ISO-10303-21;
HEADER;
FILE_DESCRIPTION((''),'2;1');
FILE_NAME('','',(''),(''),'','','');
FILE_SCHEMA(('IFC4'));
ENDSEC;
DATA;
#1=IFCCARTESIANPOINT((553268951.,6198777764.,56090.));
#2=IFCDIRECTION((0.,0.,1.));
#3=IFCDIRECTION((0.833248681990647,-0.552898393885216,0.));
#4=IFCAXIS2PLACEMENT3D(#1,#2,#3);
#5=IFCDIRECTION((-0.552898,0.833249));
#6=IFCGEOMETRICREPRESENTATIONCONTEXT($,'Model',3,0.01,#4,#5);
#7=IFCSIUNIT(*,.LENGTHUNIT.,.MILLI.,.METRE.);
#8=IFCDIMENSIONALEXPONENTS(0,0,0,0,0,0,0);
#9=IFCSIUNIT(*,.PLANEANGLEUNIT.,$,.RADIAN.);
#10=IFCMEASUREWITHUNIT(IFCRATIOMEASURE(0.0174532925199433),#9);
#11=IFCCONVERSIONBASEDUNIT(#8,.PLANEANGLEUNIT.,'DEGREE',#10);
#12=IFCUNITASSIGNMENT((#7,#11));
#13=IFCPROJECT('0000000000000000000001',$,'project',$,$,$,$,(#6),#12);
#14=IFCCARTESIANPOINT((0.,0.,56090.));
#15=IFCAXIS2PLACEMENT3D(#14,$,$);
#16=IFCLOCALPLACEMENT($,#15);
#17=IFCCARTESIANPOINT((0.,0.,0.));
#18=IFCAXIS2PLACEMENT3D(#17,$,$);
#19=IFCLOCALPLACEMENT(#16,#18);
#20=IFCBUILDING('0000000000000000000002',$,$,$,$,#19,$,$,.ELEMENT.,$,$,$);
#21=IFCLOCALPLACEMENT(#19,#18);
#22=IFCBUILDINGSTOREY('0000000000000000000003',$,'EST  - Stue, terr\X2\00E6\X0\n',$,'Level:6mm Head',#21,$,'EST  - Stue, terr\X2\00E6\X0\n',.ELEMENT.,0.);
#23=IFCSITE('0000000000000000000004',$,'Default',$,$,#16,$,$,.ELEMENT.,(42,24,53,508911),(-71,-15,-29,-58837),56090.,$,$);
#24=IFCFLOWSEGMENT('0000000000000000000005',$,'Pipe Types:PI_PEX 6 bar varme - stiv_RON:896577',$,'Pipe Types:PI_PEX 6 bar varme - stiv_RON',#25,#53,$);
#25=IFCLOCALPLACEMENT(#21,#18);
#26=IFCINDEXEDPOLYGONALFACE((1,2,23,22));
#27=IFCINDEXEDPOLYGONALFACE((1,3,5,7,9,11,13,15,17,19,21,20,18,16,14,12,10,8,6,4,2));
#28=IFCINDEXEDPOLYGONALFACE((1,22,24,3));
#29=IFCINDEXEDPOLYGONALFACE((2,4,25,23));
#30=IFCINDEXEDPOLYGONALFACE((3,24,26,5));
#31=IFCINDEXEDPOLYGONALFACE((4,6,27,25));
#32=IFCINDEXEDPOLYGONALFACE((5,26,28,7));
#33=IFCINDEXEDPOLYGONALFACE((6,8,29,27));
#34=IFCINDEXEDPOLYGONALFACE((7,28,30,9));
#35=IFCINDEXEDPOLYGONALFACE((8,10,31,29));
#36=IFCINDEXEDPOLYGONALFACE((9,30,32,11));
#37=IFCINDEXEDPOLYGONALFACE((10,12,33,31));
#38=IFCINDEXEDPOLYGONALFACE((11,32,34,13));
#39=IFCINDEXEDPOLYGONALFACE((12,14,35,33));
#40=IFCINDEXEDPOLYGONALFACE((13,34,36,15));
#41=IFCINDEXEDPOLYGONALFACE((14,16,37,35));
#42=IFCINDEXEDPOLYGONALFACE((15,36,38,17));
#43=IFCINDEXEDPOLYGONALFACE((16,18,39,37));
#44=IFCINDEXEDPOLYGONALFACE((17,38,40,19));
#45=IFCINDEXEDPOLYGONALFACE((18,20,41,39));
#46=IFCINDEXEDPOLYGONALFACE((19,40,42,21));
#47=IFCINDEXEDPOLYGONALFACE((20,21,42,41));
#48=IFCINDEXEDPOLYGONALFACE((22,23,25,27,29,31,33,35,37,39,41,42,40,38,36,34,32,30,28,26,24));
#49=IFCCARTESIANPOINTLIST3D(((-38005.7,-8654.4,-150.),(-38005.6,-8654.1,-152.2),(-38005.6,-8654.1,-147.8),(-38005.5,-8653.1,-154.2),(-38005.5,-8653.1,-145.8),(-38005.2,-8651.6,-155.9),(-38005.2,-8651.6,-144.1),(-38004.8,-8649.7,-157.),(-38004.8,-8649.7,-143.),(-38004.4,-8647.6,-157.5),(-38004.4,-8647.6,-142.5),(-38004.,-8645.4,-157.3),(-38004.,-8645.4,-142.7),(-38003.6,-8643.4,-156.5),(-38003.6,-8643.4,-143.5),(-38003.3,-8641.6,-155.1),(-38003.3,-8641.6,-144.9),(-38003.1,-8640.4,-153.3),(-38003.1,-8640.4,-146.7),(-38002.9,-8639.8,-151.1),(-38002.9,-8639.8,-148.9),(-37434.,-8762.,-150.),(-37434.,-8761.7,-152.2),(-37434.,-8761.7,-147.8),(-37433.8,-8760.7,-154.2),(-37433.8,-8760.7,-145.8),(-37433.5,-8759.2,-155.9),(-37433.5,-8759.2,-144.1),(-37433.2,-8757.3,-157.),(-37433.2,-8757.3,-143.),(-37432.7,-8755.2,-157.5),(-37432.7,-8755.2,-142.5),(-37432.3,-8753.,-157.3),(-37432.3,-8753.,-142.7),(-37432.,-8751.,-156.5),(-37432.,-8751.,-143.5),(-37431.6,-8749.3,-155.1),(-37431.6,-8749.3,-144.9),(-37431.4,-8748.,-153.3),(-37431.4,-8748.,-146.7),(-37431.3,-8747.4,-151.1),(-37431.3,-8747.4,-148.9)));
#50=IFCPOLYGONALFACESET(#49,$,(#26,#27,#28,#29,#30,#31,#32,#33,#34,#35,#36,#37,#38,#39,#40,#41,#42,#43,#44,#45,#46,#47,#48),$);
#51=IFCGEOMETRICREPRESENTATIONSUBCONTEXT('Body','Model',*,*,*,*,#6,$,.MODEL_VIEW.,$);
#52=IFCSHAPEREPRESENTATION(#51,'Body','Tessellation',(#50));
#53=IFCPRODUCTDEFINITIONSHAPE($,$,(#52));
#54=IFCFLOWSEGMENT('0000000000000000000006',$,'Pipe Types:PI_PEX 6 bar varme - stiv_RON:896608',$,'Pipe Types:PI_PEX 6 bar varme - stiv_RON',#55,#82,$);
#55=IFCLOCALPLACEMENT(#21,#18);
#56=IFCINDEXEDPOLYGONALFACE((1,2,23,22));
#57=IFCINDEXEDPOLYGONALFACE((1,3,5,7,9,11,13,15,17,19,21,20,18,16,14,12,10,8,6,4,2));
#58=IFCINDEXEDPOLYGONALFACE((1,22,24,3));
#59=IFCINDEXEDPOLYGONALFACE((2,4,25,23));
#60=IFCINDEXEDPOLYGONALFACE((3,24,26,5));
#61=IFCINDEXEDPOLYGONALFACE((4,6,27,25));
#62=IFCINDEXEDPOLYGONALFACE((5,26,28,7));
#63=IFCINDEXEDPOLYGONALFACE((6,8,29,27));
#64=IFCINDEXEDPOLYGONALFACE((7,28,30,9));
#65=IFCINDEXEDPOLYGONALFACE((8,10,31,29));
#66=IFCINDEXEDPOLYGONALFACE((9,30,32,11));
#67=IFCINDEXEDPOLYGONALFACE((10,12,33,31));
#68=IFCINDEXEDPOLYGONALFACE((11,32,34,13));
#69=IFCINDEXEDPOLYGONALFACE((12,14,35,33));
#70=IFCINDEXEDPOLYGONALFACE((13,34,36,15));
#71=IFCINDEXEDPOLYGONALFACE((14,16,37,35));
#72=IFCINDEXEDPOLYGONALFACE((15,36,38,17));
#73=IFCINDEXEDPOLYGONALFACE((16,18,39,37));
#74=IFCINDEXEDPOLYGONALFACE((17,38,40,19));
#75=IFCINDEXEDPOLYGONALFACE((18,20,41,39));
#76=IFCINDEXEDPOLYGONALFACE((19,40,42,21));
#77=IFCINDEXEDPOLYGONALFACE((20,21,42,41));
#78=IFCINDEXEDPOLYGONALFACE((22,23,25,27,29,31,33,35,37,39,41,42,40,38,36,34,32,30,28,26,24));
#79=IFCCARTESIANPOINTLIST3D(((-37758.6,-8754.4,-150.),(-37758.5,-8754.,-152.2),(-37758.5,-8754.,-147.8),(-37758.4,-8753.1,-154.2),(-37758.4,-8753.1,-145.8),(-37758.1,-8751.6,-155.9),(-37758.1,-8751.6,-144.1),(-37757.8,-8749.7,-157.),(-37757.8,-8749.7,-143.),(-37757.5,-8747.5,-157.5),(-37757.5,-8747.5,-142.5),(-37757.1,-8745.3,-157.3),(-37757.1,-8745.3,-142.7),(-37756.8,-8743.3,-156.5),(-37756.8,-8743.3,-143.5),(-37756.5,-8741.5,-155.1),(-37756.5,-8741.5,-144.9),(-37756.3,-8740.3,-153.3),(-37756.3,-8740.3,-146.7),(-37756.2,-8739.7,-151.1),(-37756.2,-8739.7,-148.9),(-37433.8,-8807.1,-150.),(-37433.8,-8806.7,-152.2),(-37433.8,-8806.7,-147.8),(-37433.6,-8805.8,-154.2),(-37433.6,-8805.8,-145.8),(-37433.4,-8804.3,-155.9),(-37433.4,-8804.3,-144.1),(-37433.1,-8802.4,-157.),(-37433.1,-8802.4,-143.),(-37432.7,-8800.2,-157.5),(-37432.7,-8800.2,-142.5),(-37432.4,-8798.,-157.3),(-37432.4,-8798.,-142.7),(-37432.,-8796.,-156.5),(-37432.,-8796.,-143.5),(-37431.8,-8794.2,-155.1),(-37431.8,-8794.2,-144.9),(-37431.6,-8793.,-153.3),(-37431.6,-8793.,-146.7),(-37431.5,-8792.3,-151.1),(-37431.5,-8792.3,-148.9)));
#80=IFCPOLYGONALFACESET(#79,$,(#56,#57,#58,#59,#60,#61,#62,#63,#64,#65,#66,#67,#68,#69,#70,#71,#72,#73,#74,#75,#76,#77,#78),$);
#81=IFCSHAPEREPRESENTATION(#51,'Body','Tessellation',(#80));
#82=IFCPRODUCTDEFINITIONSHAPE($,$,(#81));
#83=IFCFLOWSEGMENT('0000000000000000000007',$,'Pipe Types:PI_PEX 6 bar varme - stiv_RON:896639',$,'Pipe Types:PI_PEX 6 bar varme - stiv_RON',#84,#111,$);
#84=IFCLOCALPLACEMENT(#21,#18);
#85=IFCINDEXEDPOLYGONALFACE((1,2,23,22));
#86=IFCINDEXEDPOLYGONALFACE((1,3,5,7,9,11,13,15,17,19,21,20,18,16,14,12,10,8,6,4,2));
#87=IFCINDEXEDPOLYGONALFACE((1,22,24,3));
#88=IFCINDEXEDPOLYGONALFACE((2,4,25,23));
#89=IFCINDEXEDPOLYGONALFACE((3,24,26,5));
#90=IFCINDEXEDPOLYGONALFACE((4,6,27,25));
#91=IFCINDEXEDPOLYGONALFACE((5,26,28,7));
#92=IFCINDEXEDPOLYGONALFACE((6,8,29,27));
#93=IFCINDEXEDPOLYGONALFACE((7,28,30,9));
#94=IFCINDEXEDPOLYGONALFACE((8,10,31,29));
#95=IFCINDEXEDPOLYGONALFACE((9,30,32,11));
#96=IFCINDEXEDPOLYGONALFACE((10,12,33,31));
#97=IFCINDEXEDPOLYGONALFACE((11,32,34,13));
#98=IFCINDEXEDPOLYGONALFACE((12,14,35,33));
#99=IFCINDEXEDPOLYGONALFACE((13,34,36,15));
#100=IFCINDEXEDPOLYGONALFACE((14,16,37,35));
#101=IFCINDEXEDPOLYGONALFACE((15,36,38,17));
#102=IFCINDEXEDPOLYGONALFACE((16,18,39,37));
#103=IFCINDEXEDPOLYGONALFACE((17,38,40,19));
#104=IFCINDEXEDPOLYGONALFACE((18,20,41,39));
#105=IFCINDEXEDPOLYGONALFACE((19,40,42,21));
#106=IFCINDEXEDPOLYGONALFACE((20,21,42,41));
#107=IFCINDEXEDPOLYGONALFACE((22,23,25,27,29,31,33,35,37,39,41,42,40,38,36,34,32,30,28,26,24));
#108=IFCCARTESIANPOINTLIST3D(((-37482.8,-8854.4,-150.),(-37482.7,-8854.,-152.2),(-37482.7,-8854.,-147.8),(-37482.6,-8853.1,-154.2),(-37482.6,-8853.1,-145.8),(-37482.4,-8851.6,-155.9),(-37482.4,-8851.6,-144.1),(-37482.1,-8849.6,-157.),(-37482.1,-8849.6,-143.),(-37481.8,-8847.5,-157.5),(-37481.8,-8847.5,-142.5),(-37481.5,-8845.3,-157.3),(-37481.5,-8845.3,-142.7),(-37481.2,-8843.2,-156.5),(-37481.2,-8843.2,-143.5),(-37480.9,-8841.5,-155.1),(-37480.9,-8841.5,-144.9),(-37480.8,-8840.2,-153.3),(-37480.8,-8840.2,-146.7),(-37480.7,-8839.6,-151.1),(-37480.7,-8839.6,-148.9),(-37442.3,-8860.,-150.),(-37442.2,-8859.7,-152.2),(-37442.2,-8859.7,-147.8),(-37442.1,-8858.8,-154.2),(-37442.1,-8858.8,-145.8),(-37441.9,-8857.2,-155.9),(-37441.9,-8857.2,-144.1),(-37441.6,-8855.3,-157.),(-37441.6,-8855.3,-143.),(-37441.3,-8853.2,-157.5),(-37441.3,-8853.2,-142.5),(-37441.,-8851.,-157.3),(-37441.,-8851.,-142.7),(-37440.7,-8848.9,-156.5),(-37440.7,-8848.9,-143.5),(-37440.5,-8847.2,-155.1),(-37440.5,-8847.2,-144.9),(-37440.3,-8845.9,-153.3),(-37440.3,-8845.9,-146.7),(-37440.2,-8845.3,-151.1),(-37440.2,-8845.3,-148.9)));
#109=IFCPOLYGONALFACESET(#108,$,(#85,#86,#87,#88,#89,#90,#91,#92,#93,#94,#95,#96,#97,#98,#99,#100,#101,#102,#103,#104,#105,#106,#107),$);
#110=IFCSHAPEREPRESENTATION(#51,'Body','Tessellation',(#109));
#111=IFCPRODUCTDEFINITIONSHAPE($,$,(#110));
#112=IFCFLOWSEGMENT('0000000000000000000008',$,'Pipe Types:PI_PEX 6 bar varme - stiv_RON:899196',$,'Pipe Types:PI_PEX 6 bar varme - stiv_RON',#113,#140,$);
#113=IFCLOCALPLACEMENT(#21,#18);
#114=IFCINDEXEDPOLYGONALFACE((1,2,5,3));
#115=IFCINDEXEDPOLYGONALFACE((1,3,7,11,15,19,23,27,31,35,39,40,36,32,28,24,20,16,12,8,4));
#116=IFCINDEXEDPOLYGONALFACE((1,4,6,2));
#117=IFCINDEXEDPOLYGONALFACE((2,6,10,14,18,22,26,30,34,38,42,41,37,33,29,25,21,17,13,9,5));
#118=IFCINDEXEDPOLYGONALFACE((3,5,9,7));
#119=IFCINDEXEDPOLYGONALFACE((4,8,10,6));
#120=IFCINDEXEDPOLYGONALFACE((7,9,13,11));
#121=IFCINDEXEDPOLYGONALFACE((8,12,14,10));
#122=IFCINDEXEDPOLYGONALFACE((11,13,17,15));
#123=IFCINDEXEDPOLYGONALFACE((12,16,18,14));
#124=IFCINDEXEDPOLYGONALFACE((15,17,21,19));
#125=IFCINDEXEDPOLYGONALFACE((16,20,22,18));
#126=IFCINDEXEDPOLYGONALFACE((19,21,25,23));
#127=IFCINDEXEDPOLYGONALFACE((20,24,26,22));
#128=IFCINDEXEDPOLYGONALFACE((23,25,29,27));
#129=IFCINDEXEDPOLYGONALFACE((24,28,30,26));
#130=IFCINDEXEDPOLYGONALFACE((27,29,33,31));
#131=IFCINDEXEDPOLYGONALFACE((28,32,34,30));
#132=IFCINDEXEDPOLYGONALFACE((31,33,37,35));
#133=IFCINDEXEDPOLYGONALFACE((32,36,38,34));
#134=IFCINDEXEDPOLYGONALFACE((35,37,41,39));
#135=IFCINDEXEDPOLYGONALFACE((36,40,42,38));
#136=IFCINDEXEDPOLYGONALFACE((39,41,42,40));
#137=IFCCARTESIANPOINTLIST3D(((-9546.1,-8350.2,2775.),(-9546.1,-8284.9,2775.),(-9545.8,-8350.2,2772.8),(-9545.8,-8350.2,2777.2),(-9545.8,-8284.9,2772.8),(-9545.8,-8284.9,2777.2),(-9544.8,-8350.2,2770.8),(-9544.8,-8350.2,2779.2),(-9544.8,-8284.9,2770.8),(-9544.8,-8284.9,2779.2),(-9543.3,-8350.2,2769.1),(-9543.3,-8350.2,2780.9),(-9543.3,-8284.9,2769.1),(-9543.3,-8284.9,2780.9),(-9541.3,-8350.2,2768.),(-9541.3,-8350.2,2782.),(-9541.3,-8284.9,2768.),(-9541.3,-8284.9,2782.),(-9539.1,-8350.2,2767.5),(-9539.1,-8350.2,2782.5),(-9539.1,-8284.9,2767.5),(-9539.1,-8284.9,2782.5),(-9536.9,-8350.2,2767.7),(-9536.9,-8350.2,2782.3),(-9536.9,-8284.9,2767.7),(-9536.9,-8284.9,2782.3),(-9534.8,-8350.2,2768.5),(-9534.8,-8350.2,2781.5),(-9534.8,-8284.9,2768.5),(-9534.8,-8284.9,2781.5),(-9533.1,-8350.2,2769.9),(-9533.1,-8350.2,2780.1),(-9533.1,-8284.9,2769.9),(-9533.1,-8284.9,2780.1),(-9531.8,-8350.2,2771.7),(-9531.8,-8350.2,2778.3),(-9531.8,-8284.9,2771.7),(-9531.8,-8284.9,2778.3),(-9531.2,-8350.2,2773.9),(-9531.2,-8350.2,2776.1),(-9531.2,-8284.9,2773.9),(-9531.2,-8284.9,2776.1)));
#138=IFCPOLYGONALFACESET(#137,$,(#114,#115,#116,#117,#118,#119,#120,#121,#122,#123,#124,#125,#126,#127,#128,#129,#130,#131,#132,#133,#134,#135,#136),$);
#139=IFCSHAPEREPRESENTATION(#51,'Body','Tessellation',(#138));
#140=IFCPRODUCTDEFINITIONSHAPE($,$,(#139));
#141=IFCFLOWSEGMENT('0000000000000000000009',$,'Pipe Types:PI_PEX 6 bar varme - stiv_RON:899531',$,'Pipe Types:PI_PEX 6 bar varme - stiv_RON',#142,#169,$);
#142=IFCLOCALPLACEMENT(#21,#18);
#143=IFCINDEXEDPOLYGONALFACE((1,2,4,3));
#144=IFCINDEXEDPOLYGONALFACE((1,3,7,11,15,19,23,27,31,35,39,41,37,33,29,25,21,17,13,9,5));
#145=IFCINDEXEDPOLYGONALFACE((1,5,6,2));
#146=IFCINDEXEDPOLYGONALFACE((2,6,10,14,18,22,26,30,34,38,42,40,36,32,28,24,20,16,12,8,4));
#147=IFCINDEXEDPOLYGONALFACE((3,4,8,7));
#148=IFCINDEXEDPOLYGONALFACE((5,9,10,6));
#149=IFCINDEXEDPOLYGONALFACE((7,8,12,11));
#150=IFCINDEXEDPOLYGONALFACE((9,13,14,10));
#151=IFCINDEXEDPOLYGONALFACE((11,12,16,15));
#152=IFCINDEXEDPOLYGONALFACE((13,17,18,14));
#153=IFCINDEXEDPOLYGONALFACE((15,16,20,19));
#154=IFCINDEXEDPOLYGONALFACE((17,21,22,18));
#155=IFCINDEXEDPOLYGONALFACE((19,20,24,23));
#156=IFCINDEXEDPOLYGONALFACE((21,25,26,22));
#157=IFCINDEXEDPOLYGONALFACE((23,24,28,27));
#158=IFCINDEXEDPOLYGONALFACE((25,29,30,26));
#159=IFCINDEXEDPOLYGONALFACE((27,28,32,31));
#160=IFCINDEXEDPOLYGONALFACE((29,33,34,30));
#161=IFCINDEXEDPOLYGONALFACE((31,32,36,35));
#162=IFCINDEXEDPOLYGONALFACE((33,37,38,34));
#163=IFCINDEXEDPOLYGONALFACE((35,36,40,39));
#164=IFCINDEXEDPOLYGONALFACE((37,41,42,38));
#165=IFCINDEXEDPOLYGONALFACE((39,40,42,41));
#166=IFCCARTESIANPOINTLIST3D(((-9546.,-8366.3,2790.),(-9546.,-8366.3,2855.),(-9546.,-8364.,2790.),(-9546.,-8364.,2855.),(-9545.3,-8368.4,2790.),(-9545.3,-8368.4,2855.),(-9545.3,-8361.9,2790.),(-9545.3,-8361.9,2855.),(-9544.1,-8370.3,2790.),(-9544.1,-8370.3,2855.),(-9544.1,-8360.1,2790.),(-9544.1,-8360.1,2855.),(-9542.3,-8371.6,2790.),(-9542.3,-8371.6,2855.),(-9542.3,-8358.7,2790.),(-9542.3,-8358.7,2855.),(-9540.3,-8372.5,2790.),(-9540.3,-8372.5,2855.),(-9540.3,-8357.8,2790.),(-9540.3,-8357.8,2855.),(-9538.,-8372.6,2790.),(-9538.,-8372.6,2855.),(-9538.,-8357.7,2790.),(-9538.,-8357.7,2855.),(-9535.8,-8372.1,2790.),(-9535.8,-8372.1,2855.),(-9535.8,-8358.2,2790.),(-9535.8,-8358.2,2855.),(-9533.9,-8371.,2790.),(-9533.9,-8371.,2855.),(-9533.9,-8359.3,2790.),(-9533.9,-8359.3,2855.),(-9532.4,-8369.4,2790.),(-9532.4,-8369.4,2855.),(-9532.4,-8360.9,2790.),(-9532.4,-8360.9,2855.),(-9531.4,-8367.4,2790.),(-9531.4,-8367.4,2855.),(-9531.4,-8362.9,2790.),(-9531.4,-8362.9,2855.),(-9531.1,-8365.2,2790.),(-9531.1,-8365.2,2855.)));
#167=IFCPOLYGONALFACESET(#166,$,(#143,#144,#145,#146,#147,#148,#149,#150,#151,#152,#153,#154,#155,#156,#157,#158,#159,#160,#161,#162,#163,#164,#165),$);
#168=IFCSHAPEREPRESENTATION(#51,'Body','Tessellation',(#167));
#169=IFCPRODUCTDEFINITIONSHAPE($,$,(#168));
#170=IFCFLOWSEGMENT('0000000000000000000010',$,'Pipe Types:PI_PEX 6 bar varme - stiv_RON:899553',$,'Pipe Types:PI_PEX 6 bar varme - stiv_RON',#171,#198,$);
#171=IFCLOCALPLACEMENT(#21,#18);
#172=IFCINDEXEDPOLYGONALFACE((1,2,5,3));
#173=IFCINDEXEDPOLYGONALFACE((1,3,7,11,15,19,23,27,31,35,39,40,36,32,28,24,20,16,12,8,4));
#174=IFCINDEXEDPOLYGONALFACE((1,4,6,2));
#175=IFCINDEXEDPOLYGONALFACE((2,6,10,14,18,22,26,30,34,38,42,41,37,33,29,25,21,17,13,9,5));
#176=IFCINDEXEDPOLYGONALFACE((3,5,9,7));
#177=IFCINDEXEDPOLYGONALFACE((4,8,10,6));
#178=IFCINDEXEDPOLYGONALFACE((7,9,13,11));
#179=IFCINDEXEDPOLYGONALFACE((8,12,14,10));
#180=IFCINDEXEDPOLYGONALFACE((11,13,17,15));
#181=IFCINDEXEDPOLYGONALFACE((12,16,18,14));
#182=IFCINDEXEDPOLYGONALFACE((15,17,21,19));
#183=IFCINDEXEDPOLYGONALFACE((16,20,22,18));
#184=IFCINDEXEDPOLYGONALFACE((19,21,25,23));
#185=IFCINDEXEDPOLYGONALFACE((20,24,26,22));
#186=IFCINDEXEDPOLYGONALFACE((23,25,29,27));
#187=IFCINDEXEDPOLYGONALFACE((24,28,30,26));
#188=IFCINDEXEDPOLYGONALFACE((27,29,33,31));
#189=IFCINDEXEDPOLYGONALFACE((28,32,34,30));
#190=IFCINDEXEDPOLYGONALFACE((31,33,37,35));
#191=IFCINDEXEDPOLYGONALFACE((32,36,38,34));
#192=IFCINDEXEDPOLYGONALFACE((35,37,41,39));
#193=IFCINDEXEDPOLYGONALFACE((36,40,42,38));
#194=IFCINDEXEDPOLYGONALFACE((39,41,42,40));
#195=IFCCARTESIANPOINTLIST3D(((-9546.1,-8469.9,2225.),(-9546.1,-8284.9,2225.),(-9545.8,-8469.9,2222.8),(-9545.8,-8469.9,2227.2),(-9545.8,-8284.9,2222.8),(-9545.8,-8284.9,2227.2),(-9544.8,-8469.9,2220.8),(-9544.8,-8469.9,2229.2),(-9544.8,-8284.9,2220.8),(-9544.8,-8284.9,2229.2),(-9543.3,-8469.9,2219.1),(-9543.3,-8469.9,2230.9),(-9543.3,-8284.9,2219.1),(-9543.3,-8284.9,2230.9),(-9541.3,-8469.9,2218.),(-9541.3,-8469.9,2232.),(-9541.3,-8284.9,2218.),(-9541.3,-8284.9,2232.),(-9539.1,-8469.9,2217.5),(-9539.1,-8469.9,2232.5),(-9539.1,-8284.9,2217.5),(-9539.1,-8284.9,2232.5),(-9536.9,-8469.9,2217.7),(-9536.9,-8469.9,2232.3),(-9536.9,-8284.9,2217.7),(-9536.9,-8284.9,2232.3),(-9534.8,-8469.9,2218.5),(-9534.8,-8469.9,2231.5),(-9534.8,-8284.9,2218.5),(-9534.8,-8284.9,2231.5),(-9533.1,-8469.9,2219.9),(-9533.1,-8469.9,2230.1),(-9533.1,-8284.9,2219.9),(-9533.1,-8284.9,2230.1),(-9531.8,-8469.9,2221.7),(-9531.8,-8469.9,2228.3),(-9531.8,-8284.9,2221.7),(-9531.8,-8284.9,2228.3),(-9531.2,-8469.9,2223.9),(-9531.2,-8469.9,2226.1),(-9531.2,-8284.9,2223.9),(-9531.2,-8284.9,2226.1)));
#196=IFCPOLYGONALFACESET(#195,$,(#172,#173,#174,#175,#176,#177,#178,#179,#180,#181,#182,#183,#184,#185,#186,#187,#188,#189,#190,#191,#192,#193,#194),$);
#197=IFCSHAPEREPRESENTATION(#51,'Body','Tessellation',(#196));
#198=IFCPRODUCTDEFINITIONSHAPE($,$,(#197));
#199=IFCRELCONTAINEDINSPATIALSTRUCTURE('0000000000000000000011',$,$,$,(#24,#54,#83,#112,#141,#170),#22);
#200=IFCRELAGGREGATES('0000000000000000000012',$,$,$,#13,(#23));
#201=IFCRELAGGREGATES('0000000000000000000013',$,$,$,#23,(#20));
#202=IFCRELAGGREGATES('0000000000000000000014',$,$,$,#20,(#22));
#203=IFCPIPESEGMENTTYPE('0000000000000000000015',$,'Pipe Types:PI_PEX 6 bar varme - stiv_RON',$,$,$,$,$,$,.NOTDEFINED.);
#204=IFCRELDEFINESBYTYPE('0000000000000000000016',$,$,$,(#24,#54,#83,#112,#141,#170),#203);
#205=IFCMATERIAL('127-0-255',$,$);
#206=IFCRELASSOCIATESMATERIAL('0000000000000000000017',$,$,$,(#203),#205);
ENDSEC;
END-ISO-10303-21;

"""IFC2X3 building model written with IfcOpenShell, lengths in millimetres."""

from ifc_helpers import new_model, entity, si_unit, converted_unit, direction, frame, frame_2d, origin, origin_2d_with_axis, place, context, subcontext, project, spatial, circle, extrude, material, type_object, element, save


model = new_model("IFC2X3")

# Units and contexts
model_context = context("Model", 3, precision=0.01, world=frame((553268951.0, 6198777764.0, 56090.0), z_axis=(0.0, 0.0, 1.0), x_axis=(0.833248681990647, -0.552898393885216, 0.0)), true_north=direction((-0.552898, 0.833249)))
body_context = subcontext(model_context, "Body", "Model", "MODEL_VIEW")
ifc_project = project(units=[si_unit("LENGTHUNIT", "METRE", prefix="MILLI"), converted_unit("PLANEANGLEUNIT", "DEGREE", entity("IfcRatioMeasure", 0.0174532925199433), si_unit("PLANEANGLEUNIT", "RADIAN"), dimensions=[0, 0, 0, 0, 0, 0, 0])], contexts=[model_context])

# Site, building, storey
site_placement = place(None, frame((0.0, 0.0, 56090.0)))
site = spatial("IfcSite", under=ifc_project, at=site_placement, Name="Default", CompositionType="ELEMENT", RefLatitude=(42, 24, 53, 508911), RefLongitude=(-71, -15, -29, -58837), RefElevation=56090.0)
building_placement = place(site_placement, origin())
building = spatial("IfcBuilding", under=site, at=building_placement, CompositionType="ELEMENT")
storey_placement = place(building_placement, frame((0.0, 0.0, 0.0)))
storey = spatial("IfcBuildingStorey", under=building, at=storey_placement, Name="EST  - Stue, terræn", ObjectType="Level:6mm Head", LongName="EST  - Stue, terræn", CompositionType="ELEMENT", Elevation=0.0)

# Flow segments
ifc_material_1 = material(Name="127-0-255")
pipe_segment_type_1 = type_object("IfcPipeSegmentType", Name="Pipe Types:PI_PEX 6 bar varme - stiv_RON", PredefinedType="NOTDEFINED", material=ifc_material_1)
flow_segment_1_placement = place(storey_placement, origin())
element("IfcFlowSegment", 1, at=flow_segment_1_placement, inside=storey, type_object=pipe_segment_type_1, Name="Pipe Types:PI_PEX 6 bar varme - stiv_RON:896577", ObjectType="Pipe Types:PI_PEX 6 bar varme - stiv_RON", context=body_context, shape_type="SweptSolid", body=[
    extrude(circle(Radius=7.5, at=origin_2d_with_axis()), frame((-38004.3, -8647.0, -150.0), z_axis=(0.982739, -0.184999, 0.0), x_axis=(-0.184999, -0.982739, 0.0)), (0.0, 0.0, 1.0), 581.7),
])
flow_segment_2_placement = place(storey_placement, origin())
element("IfcFlowSegment", 2, at=flow_segment_2_placement, inside=storey, type_object=pipe_segment_type_1, Name="Pipe Types:PI_PEX 6 bar varme - stiv_RON:896608", ObjectType="Pipe Types:PI_PEX 6 bar varme - stiv_RON", context=body_context, shape_type="SweptSolid", body=[
    extrude(circle(Radius=7.5, at=frame_2d((0.0, 0.0), x_axis=(1.0, 0.0))), frame((-37432.6, -8799.7, -150.0), z_axis=(-0.987096, 0.160132, 0.0), x_axis=(-0.160132, -0.987096, 0.0)), (0.0, 0.0, 1.0), 329.0),
])
flow_segment_3_placement = place(storey_placement, origin())
element("IfcFlowSegment", 3, at=flow_segment_3_placement, inside=storey, type_object=pipe_segment_type_1, Name="Pipe Types:PI_PEX 6 bar varme - stiv_RON:896639", ObjectType="Pipe Types:PI_PEX 6 bar varme - stiv_RON", context=body_context, shape_type="SweptSolid", body=[
    extrude(circle(Radius=7.5, at=frame_2d((0.0, 0.0), x_axis=(1.0, 0.0))), frame((-37481.7, -8846.9, -150.0), z_axis=(0.990268, -0.139173, 0.0), x_axis=(-0.139173, -0.990268, 0.0)), (0.0, 0.0, 1.0), 40.9),
])
flow_segment_4_placement = place(storey_placement, origin())
element("IfcFlowSegment", 4, at=flow_segment_4_placement, inside=storey, type_object=pipe_segment_type_1, Name="Pipe Types:PI_PEX 6 bar varme - stiv_RON:899196", ObjectType="Pipe Types:PI_PEX 6 bar varme - stiv_RON", context=body_context, shape_type="SweptSolid", body=[
    extrude(circle(Radius=7.5, at=frame_2d((0.0, 0.0), x_axis=(1.0, 0.0))), frame((-9538.6, -8350.2, 2775.0), z_axis=(0.0, 1.0, 0.0), x_axis=(-1.0, 0.0, 0.0)), (0.0, 0.0, 1.0), 65.3),
])
flow_segment_5_placement = place(storey_placement, origin())
element("IfcFlowSegment", 5, at=flow_segment_5_placement, inside=storey, type_object=pipe_segment_type_1, Name="Pipe Types:PI_PEX 6 bar varme - stiv_RON:899531", ObjectType="Pipe Types:PI_PEX 6 bar varme - stiv_RON", context=body_context, shape_type="SweptSolid", body=[
    extrude(circle(Radius=7.5, at=origin_2d_with_axis()), frame((-9538.6, -8365.2, 2790.0)), (0.0, 0.0, 1.0), 65.0),
])
flow_segment_6_placement = place(storey_placement, origin())
element("IfcFlowSegment", 6, at=flow_segment_6_placement, inside=storey, type_object=pipe_segment_type_1, Name="Pipe Types:PI_PEX 6 bar varme - stiv_RON:899553", ObjectType="Pipe Types:PI_PEX 6 bar varme - stiv_RON", context=body_context, shape_type="SweptSolid", body=[
    extrude(circle(Radius=7.5, at=frame_2d((0.0, 0.0), x_axis=(1.0, 0.0))), frame((-9538.6, -8469.9, 2225.0), z_axis=(0.0, 1.0, 0.0), x_axis=(-1.0, 0.0, 0.0)), (0.0, 0.0, 1.0), 185.0),
])

save(model, "model.ifc")
